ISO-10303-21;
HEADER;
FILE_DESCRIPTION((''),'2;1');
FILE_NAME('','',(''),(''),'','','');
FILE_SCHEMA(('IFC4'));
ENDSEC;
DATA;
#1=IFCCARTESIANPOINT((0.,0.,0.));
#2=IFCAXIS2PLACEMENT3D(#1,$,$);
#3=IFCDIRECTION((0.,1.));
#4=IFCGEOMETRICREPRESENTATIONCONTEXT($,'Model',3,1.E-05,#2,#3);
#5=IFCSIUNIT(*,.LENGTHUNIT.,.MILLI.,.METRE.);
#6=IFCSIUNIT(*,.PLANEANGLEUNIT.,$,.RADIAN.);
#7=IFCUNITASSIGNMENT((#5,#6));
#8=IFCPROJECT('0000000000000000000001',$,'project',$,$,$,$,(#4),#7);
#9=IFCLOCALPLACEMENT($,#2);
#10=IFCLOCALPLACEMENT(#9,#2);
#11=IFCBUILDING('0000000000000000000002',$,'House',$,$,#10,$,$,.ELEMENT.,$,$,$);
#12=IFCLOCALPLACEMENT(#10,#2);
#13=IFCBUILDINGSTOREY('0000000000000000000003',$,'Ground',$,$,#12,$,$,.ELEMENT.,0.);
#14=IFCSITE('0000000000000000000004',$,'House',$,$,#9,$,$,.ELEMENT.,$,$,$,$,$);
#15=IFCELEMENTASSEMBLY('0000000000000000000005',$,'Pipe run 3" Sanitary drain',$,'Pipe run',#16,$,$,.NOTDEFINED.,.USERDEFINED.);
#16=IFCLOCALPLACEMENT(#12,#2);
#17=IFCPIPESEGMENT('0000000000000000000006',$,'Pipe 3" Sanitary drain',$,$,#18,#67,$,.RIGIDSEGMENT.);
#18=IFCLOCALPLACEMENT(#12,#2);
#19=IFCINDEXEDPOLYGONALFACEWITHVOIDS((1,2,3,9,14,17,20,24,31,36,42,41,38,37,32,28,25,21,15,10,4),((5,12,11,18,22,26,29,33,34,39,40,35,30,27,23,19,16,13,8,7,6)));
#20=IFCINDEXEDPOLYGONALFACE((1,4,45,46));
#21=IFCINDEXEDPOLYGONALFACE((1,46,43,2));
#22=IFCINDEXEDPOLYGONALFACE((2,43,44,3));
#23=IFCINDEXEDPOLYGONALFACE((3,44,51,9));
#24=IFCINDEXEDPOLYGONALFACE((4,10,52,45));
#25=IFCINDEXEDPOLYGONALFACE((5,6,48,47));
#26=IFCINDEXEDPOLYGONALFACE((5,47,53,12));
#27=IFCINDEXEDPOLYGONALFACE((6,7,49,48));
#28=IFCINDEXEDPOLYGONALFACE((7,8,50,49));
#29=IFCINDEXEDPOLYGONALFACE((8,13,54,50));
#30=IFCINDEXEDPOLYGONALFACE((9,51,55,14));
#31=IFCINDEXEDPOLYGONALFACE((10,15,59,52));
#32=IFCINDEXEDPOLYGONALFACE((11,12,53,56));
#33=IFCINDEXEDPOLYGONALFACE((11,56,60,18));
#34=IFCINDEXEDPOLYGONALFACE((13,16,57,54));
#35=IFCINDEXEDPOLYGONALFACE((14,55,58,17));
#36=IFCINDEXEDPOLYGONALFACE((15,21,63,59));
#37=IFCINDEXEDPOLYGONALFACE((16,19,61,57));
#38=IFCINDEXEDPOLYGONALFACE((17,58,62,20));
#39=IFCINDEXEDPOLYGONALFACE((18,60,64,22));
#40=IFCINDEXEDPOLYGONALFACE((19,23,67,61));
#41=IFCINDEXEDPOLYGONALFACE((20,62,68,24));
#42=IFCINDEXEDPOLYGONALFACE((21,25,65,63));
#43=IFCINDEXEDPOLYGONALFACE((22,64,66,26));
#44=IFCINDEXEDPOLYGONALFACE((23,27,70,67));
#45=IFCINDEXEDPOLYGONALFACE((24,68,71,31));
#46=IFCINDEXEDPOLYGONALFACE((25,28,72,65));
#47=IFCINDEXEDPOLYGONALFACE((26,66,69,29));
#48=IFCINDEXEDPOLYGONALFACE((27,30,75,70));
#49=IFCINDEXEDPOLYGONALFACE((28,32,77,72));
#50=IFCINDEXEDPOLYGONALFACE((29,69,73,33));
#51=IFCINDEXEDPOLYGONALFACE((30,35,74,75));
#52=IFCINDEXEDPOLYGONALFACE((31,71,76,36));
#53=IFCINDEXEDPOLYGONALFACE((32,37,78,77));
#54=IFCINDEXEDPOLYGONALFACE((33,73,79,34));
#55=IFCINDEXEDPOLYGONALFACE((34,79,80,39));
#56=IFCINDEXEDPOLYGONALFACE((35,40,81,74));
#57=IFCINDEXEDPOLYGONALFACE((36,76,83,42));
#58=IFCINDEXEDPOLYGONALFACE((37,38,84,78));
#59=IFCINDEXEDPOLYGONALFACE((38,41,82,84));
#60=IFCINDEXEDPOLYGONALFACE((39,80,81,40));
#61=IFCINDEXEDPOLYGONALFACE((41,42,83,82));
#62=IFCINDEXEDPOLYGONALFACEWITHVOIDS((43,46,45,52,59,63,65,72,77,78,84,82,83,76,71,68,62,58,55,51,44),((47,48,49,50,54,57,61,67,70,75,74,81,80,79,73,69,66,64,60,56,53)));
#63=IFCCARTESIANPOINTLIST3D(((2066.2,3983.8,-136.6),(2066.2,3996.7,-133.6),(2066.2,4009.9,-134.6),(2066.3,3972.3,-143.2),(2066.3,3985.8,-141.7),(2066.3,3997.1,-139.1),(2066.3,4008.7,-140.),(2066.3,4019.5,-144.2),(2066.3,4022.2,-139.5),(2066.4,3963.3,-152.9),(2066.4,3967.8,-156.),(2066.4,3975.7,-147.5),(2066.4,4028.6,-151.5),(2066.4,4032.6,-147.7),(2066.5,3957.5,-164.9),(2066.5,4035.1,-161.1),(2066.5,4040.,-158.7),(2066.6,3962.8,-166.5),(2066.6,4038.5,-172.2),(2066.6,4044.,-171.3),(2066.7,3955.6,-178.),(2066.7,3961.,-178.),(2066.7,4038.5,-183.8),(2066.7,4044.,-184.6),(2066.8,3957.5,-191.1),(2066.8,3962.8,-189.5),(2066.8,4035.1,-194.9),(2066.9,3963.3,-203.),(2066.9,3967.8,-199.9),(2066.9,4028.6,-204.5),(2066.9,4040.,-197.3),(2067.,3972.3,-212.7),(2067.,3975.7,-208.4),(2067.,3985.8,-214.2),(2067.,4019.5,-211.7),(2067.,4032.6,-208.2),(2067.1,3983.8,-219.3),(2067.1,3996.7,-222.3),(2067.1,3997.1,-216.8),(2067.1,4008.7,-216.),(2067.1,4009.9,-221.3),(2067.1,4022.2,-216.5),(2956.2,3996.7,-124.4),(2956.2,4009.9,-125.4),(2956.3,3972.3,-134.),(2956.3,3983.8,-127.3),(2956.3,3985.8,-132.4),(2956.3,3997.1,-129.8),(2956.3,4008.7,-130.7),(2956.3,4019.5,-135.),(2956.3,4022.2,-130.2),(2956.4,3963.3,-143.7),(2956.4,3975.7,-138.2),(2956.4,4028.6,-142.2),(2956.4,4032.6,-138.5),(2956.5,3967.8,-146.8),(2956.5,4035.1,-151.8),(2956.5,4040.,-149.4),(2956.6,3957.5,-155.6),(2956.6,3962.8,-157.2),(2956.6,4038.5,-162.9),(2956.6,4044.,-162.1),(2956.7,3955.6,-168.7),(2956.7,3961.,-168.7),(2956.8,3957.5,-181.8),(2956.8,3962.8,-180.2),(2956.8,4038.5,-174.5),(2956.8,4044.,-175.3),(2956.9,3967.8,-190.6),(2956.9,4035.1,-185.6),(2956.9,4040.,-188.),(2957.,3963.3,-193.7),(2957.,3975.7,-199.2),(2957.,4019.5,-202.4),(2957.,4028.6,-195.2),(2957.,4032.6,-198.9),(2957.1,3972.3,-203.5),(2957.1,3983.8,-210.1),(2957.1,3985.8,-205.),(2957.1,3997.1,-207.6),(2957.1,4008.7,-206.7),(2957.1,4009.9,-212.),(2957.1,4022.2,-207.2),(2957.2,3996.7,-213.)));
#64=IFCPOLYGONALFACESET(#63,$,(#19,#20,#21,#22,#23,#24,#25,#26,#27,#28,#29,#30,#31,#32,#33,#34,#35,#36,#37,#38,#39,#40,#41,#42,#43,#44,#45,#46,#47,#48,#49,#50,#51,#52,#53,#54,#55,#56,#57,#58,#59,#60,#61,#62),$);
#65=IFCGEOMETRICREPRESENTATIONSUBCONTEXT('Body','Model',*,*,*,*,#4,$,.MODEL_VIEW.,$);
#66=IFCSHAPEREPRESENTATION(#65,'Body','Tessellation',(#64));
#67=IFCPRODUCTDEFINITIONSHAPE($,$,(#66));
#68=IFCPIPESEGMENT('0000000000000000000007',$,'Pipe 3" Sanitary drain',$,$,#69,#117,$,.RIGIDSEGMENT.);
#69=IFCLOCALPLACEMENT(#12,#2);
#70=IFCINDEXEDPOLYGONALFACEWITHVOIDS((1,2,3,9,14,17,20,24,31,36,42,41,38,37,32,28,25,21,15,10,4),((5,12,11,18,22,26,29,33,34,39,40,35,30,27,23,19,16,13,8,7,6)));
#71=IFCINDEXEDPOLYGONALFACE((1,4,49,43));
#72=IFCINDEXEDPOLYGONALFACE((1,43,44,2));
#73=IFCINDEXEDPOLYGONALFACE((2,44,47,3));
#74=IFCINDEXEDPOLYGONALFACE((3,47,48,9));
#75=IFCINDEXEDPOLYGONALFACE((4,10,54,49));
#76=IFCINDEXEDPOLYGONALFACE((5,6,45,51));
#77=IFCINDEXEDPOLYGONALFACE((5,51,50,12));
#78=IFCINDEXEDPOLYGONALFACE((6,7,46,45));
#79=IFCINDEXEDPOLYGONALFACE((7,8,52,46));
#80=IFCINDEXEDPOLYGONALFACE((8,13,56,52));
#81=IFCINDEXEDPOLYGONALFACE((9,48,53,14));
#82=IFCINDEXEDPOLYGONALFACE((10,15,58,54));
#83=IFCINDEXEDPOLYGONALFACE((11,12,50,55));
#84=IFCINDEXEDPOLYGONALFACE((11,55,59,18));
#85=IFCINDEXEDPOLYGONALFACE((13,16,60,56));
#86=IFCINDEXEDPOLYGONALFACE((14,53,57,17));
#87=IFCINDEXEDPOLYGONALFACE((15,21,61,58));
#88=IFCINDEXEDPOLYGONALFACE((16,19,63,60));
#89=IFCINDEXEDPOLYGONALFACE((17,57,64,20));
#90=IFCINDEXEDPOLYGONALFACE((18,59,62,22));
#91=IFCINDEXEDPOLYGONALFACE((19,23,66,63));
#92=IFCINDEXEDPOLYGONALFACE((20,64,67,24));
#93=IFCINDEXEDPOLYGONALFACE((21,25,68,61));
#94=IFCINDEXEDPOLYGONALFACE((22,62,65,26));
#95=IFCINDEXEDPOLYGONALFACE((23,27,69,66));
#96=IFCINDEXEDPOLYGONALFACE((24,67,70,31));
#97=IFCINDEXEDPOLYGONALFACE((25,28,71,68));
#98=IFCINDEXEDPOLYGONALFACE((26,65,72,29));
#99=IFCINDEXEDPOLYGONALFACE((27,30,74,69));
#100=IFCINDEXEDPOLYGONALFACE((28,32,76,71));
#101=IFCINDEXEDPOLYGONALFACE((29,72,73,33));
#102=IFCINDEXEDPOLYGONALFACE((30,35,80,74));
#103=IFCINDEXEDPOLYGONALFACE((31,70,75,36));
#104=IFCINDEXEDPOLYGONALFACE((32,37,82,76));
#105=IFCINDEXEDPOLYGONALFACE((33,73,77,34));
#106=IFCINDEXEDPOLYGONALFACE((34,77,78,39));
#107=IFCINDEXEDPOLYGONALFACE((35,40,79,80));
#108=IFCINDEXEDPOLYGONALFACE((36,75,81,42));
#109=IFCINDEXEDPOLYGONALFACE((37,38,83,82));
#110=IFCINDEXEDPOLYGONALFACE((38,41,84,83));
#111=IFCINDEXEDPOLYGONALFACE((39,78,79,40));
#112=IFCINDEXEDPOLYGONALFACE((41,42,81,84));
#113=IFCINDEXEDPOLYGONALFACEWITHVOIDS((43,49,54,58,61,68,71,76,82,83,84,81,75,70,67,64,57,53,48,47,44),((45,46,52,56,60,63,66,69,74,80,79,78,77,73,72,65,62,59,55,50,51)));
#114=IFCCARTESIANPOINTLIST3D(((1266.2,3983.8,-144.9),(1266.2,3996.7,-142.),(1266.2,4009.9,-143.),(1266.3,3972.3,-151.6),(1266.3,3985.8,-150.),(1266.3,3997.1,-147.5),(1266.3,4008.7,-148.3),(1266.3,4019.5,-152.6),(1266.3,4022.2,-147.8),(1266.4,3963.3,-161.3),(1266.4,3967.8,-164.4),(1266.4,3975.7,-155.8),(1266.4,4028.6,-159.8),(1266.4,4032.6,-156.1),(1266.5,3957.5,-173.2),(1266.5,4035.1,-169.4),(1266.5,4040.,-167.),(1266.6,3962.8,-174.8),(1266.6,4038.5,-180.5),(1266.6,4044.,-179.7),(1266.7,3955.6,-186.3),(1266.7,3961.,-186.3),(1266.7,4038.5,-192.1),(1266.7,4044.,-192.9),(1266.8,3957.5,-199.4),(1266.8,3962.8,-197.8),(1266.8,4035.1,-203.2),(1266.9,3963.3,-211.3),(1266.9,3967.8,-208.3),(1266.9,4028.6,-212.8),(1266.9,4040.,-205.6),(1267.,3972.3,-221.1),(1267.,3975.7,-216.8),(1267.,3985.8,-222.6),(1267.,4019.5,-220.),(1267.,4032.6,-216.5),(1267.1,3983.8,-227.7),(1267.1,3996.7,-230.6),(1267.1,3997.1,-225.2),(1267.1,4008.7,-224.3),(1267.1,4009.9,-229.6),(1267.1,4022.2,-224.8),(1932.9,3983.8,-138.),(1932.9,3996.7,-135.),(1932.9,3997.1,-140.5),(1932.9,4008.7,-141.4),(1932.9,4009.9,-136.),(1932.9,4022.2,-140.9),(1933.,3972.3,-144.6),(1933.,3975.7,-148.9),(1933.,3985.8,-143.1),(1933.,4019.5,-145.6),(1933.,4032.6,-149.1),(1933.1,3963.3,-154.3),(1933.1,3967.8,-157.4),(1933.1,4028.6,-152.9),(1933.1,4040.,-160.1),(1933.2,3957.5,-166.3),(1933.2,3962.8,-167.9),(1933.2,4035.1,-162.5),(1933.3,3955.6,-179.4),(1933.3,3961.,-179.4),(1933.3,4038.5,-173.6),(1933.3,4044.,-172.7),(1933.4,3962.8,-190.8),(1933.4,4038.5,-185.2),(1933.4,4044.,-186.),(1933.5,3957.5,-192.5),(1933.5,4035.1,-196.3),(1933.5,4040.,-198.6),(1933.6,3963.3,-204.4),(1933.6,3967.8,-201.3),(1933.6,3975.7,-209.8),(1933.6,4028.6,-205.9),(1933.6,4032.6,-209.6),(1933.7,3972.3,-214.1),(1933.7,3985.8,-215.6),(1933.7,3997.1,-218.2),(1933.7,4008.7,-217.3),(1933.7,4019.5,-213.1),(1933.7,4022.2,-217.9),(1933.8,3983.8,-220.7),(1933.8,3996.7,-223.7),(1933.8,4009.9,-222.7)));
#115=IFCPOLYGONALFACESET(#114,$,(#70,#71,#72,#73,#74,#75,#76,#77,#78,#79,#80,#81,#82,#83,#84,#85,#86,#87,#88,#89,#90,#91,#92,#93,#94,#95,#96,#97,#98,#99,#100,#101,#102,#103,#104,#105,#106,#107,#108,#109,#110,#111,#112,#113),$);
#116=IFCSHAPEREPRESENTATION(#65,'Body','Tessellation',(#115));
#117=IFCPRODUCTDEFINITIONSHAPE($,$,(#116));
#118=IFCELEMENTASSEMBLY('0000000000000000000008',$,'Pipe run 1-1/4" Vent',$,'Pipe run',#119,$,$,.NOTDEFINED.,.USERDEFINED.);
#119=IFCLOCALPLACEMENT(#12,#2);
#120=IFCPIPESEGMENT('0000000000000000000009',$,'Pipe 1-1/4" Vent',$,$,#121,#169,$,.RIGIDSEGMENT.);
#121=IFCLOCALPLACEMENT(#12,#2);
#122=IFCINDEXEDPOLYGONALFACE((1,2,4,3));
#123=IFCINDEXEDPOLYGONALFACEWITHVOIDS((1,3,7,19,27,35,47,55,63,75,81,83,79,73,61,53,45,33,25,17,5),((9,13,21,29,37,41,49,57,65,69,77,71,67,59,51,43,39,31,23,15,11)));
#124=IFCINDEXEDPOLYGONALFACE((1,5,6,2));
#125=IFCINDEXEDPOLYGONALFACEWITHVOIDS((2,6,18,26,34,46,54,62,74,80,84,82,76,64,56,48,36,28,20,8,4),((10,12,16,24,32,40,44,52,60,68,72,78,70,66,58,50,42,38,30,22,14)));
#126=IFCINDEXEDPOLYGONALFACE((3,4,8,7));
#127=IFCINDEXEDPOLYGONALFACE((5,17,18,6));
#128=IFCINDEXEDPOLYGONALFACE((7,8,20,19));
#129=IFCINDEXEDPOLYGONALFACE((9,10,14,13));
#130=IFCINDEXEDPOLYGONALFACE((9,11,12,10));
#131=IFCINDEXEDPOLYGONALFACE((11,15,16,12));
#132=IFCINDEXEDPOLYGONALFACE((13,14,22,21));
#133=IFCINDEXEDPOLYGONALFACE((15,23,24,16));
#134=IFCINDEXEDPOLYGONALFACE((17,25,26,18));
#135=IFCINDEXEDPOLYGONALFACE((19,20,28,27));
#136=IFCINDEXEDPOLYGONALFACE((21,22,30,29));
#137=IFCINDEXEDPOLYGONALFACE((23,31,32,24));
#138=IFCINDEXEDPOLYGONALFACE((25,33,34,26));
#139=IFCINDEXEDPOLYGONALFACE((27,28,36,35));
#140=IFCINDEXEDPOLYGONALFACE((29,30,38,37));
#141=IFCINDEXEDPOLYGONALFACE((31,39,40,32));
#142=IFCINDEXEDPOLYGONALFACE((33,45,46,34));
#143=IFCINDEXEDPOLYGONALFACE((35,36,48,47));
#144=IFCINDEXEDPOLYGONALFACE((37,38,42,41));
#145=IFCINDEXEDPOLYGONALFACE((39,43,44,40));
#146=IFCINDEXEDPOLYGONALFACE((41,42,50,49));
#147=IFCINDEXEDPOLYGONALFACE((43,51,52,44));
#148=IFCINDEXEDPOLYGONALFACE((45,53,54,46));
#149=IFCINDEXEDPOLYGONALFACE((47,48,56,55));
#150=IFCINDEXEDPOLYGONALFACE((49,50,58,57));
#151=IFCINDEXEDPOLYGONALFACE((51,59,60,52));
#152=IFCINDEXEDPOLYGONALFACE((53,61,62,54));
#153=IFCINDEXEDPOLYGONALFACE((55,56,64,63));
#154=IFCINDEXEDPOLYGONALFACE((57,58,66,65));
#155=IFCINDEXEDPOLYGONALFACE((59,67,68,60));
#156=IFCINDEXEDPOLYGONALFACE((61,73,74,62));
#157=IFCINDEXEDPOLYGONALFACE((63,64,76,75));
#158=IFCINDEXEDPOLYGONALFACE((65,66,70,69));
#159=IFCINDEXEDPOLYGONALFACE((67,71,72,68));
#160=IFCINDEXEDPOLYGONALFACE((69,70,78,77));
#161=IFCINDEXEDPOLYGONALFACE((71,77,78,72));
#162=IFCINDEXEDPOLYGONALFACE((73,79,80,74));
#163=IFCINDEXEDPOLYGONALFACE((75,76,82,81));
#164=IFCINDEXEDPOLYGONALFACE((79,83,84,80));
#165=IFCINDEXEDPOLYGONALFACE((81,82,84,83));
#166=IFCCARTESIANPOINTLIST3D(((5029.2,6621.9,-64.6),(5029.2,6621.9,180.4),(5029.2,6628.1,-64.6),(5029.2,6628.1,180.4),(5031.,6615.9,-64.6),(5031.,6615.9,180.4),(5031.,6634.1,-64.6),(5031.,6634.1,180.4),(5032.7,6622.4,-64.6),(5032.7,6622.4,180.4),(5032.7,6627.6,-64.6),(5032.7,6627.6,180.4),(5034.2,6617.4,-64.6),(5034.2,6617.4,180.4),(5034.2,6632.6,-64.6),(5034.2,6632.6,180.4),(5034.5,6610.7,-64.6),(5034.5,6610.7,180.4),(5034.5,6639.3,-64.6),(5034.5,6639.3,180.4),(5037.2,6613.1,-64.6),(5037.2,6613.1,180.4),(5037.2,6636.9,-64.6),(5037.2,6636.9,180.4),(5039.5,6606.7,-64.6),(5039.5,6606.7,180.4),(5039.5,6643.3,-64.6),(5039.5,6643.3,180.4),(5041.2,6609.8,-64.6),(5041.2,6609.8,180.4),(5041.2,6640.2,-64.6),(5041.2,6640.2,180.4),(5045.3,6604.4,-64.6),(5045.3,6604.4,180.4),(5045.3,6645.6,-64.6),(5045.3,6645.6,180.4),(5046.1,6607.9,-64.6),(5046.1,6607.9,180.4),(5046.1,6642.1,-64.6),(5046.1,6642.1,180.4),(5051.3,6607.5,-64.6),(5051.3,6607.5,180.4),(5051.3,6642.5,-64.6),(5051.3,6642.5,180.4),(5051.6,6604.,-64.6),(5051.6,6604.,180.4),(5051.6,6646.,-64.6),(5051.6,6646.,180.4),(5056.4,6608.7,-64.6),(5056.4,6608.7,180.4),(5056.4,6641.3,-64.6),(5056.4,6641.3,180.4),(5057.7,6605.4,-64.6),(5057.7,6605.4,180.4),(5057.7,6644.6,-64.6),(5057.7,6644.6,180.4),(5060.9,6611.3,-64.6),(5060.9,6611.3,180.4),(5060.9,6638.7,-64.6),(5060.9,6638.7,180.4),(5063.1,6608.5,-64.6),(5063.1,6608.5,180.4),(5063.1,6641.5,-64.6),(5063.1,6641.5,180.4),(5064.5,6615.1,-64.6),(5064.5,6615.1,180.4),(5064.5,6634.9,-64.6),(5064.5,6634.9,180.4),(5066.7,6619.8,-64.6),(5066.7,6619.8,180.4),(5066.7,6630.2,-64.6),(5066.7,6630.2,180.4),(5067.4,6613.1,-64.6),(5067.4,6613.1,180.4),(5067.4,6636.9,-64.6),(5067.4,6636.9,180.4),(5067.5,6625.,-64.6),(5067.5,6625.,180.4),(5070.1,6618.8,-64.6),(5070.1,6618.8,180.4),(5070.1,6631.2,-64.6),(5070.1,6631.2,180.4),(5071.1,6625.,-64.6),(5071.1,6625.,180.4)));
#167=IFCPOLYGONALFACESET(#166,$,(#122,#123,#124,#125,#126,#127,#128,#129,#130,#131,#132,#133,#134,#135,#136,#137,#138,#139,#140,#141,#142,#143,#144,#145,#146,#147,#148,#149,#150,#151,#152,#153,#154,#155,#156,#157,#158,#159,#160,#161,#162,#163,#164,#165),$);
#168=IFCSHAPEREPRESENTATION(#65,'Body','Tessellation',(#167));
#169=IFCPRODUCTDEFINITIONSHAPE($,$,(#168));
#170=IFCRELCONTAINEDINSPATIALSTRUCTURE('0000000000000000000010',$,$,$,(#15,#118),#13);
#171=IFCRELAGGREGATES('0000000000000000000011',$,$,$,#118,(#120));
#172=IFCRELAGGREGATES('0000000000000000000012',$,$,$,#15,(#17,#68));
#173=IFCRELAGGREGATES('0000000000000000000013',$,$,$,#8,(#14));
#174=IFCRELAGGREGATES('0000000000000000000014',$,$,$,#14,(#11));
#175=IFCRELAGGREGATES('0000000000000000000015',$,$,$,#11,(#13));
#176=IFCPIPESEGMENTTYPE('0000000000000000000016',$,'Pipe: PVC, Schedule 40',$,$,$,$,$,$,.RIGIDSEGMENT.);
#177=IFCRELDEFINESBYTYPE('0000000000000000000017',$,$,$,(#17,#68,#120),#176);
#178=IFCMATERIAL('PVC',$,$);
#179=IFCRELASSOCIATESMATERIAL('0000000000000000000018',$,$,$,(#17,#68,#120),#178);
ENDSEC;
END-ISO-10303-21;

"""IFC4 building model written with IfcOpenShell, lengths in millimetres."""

from ifc_helpers import new_model, si_unit, direction, frame, origin, origin_with_axes, origin_2d, place, context, subcontext, project, spatial, hollow_circle, extrude, material, type_object, element, aggregate, save


model = new_model("IFC4")

# Units and contexts
model_context = context("Model", 3, precision=1e-05, world=origin(), true_north=direction((0.0, 1.0)))
body_context = subcontext(model_context, "Body", "Model", "MODEL_VIEW")
ifc_project = project(units=[si_unit("LENGTHUNIT", "METRE", prefix="MILLI"), si_unit("PLANEANGLEUNIT", "RADIAN")], contexts=[model_context])

# Site, building, storey
site_placement = place(None, origin())
site = spatial("IfcSite", under=ifc_project, at=site_placement, Name="House", CompositionType="ELEMENT")
building_placement = place(site_placement, origin())
building = spatial("IfcBuilding", under=site, at=building_placement, Name="House", CompositionType="ELEMENT")
storey_placement = place(building_placement, origin())
storey = spatial("IfcBuildingStorey", under=building, at=storey_placement, Name="Ground", CompositionType="ELEMENT", Elevation=0.0)

# Element assembly, pipe segments
ifc_material = material(Name="PVC")
pipe_segment_type = type_object("IfcPipeSegmentType", Name="Pipe: PVC, Schedule 40", PredefinedType="RIGIDSEGMENT")
assembly_1_placement = place(storey_placement, origin_with_axes())
assembly_1 = element("IfcElementAssembly", 1, at=assembly_1_placement, inside=storey, Name="Pipe run 3\" Sanitary drain", ObjectType="Pipe run", AssemblyPlace="NOTDEFINED", PredefinedType="USERDEFINED")
pipe_segment_1_placement = place(storey_placement, origin_with_axes())
pipe_segment_1 = element("IfcPipeSegment", 2, at=pipe_segment_1_placement, type_object=pipe_segment_type, material=ifc_material, Name="Pipe 3\" Sanitary drain", PredefinedType="RIGIDSEGMENT", context=body_context, shape_type="SweptSolid", body=[
    extrude(hollow_circle(Radius=44.5, WallThickness=5.5, at=origin_2d()), frame((2956.7, 4000.0, -168.7), z_axis=(-0.999946, 0.0, -0.010416), x_axis=(0.0, -1.0, 0.0)), (0.0, 0.0, 1.0), 890.1),
])
pipe_segment_2_placement = place(storey_placement, origin_with_axes())
pipe_segment_2 = element("IfcPipeSegment", 3, at=pipe_segment_2_placement, type_object=pipe_segment_type, material=ifc_material, Name="Pipe 3\" Sanitary drain", PredefinedType="RIGIDSEGMENT", context=body_context, shape_type="SweptSolid", body=[
    extrude(hollow_circle(Radius=44.5, WallThickness=5.5, at=origin_2d()), frame((1933.3, 4000.0, -179.4), z_axis=(-0.999946, 0.0, -0.010416), x_axis=(0.0, -1.0, 0.0)), (0.0, 0.0, 1.0), 666.7),
])

# Element assembly, pipe segment
assembly_2_placement = place(storey_placement, origin_with_axes())
assembly_2 = element("IfcElementAssembly", 4, at=assembly_2_placement, inside=storey, Name="Pipe run 1-1/4\" Vent", ObjectType="Pipe run", AssemblyPlace="NOTDEFINED", PredefinedType="USERDEFINED")
pipe_segment_3_placement = place(storey_placement, origin_with_axes())
pipe_segment_3 = element("IfcPipeSegment", 5, at=pipe_segment_3_placement, type_object=pipe_segment_type, material=ifc_material, Name="Pipe 1-1/4\" Vent", PredefinedType="RIGIDSEGMENT", context=body_context, shape_type="SweptSolid", body=[
    extrude(hollow_circle(Radius=21.1, WallThickness=3.6, at=origin_2d()), frame((5050.0, 6625.0, 180.4), z_axis=(0.0, 0.0, -1.0), x_axis=(1.0, 0.0, 0.0)), (0.0, 0.0, 1.0), 245.0),
])
aggregate(assembly_2, [pipe_segment_3])

aggregate(assembly_1, [pipe_segment_1, pipe_segment_2])

save(model, "model.ifc")
